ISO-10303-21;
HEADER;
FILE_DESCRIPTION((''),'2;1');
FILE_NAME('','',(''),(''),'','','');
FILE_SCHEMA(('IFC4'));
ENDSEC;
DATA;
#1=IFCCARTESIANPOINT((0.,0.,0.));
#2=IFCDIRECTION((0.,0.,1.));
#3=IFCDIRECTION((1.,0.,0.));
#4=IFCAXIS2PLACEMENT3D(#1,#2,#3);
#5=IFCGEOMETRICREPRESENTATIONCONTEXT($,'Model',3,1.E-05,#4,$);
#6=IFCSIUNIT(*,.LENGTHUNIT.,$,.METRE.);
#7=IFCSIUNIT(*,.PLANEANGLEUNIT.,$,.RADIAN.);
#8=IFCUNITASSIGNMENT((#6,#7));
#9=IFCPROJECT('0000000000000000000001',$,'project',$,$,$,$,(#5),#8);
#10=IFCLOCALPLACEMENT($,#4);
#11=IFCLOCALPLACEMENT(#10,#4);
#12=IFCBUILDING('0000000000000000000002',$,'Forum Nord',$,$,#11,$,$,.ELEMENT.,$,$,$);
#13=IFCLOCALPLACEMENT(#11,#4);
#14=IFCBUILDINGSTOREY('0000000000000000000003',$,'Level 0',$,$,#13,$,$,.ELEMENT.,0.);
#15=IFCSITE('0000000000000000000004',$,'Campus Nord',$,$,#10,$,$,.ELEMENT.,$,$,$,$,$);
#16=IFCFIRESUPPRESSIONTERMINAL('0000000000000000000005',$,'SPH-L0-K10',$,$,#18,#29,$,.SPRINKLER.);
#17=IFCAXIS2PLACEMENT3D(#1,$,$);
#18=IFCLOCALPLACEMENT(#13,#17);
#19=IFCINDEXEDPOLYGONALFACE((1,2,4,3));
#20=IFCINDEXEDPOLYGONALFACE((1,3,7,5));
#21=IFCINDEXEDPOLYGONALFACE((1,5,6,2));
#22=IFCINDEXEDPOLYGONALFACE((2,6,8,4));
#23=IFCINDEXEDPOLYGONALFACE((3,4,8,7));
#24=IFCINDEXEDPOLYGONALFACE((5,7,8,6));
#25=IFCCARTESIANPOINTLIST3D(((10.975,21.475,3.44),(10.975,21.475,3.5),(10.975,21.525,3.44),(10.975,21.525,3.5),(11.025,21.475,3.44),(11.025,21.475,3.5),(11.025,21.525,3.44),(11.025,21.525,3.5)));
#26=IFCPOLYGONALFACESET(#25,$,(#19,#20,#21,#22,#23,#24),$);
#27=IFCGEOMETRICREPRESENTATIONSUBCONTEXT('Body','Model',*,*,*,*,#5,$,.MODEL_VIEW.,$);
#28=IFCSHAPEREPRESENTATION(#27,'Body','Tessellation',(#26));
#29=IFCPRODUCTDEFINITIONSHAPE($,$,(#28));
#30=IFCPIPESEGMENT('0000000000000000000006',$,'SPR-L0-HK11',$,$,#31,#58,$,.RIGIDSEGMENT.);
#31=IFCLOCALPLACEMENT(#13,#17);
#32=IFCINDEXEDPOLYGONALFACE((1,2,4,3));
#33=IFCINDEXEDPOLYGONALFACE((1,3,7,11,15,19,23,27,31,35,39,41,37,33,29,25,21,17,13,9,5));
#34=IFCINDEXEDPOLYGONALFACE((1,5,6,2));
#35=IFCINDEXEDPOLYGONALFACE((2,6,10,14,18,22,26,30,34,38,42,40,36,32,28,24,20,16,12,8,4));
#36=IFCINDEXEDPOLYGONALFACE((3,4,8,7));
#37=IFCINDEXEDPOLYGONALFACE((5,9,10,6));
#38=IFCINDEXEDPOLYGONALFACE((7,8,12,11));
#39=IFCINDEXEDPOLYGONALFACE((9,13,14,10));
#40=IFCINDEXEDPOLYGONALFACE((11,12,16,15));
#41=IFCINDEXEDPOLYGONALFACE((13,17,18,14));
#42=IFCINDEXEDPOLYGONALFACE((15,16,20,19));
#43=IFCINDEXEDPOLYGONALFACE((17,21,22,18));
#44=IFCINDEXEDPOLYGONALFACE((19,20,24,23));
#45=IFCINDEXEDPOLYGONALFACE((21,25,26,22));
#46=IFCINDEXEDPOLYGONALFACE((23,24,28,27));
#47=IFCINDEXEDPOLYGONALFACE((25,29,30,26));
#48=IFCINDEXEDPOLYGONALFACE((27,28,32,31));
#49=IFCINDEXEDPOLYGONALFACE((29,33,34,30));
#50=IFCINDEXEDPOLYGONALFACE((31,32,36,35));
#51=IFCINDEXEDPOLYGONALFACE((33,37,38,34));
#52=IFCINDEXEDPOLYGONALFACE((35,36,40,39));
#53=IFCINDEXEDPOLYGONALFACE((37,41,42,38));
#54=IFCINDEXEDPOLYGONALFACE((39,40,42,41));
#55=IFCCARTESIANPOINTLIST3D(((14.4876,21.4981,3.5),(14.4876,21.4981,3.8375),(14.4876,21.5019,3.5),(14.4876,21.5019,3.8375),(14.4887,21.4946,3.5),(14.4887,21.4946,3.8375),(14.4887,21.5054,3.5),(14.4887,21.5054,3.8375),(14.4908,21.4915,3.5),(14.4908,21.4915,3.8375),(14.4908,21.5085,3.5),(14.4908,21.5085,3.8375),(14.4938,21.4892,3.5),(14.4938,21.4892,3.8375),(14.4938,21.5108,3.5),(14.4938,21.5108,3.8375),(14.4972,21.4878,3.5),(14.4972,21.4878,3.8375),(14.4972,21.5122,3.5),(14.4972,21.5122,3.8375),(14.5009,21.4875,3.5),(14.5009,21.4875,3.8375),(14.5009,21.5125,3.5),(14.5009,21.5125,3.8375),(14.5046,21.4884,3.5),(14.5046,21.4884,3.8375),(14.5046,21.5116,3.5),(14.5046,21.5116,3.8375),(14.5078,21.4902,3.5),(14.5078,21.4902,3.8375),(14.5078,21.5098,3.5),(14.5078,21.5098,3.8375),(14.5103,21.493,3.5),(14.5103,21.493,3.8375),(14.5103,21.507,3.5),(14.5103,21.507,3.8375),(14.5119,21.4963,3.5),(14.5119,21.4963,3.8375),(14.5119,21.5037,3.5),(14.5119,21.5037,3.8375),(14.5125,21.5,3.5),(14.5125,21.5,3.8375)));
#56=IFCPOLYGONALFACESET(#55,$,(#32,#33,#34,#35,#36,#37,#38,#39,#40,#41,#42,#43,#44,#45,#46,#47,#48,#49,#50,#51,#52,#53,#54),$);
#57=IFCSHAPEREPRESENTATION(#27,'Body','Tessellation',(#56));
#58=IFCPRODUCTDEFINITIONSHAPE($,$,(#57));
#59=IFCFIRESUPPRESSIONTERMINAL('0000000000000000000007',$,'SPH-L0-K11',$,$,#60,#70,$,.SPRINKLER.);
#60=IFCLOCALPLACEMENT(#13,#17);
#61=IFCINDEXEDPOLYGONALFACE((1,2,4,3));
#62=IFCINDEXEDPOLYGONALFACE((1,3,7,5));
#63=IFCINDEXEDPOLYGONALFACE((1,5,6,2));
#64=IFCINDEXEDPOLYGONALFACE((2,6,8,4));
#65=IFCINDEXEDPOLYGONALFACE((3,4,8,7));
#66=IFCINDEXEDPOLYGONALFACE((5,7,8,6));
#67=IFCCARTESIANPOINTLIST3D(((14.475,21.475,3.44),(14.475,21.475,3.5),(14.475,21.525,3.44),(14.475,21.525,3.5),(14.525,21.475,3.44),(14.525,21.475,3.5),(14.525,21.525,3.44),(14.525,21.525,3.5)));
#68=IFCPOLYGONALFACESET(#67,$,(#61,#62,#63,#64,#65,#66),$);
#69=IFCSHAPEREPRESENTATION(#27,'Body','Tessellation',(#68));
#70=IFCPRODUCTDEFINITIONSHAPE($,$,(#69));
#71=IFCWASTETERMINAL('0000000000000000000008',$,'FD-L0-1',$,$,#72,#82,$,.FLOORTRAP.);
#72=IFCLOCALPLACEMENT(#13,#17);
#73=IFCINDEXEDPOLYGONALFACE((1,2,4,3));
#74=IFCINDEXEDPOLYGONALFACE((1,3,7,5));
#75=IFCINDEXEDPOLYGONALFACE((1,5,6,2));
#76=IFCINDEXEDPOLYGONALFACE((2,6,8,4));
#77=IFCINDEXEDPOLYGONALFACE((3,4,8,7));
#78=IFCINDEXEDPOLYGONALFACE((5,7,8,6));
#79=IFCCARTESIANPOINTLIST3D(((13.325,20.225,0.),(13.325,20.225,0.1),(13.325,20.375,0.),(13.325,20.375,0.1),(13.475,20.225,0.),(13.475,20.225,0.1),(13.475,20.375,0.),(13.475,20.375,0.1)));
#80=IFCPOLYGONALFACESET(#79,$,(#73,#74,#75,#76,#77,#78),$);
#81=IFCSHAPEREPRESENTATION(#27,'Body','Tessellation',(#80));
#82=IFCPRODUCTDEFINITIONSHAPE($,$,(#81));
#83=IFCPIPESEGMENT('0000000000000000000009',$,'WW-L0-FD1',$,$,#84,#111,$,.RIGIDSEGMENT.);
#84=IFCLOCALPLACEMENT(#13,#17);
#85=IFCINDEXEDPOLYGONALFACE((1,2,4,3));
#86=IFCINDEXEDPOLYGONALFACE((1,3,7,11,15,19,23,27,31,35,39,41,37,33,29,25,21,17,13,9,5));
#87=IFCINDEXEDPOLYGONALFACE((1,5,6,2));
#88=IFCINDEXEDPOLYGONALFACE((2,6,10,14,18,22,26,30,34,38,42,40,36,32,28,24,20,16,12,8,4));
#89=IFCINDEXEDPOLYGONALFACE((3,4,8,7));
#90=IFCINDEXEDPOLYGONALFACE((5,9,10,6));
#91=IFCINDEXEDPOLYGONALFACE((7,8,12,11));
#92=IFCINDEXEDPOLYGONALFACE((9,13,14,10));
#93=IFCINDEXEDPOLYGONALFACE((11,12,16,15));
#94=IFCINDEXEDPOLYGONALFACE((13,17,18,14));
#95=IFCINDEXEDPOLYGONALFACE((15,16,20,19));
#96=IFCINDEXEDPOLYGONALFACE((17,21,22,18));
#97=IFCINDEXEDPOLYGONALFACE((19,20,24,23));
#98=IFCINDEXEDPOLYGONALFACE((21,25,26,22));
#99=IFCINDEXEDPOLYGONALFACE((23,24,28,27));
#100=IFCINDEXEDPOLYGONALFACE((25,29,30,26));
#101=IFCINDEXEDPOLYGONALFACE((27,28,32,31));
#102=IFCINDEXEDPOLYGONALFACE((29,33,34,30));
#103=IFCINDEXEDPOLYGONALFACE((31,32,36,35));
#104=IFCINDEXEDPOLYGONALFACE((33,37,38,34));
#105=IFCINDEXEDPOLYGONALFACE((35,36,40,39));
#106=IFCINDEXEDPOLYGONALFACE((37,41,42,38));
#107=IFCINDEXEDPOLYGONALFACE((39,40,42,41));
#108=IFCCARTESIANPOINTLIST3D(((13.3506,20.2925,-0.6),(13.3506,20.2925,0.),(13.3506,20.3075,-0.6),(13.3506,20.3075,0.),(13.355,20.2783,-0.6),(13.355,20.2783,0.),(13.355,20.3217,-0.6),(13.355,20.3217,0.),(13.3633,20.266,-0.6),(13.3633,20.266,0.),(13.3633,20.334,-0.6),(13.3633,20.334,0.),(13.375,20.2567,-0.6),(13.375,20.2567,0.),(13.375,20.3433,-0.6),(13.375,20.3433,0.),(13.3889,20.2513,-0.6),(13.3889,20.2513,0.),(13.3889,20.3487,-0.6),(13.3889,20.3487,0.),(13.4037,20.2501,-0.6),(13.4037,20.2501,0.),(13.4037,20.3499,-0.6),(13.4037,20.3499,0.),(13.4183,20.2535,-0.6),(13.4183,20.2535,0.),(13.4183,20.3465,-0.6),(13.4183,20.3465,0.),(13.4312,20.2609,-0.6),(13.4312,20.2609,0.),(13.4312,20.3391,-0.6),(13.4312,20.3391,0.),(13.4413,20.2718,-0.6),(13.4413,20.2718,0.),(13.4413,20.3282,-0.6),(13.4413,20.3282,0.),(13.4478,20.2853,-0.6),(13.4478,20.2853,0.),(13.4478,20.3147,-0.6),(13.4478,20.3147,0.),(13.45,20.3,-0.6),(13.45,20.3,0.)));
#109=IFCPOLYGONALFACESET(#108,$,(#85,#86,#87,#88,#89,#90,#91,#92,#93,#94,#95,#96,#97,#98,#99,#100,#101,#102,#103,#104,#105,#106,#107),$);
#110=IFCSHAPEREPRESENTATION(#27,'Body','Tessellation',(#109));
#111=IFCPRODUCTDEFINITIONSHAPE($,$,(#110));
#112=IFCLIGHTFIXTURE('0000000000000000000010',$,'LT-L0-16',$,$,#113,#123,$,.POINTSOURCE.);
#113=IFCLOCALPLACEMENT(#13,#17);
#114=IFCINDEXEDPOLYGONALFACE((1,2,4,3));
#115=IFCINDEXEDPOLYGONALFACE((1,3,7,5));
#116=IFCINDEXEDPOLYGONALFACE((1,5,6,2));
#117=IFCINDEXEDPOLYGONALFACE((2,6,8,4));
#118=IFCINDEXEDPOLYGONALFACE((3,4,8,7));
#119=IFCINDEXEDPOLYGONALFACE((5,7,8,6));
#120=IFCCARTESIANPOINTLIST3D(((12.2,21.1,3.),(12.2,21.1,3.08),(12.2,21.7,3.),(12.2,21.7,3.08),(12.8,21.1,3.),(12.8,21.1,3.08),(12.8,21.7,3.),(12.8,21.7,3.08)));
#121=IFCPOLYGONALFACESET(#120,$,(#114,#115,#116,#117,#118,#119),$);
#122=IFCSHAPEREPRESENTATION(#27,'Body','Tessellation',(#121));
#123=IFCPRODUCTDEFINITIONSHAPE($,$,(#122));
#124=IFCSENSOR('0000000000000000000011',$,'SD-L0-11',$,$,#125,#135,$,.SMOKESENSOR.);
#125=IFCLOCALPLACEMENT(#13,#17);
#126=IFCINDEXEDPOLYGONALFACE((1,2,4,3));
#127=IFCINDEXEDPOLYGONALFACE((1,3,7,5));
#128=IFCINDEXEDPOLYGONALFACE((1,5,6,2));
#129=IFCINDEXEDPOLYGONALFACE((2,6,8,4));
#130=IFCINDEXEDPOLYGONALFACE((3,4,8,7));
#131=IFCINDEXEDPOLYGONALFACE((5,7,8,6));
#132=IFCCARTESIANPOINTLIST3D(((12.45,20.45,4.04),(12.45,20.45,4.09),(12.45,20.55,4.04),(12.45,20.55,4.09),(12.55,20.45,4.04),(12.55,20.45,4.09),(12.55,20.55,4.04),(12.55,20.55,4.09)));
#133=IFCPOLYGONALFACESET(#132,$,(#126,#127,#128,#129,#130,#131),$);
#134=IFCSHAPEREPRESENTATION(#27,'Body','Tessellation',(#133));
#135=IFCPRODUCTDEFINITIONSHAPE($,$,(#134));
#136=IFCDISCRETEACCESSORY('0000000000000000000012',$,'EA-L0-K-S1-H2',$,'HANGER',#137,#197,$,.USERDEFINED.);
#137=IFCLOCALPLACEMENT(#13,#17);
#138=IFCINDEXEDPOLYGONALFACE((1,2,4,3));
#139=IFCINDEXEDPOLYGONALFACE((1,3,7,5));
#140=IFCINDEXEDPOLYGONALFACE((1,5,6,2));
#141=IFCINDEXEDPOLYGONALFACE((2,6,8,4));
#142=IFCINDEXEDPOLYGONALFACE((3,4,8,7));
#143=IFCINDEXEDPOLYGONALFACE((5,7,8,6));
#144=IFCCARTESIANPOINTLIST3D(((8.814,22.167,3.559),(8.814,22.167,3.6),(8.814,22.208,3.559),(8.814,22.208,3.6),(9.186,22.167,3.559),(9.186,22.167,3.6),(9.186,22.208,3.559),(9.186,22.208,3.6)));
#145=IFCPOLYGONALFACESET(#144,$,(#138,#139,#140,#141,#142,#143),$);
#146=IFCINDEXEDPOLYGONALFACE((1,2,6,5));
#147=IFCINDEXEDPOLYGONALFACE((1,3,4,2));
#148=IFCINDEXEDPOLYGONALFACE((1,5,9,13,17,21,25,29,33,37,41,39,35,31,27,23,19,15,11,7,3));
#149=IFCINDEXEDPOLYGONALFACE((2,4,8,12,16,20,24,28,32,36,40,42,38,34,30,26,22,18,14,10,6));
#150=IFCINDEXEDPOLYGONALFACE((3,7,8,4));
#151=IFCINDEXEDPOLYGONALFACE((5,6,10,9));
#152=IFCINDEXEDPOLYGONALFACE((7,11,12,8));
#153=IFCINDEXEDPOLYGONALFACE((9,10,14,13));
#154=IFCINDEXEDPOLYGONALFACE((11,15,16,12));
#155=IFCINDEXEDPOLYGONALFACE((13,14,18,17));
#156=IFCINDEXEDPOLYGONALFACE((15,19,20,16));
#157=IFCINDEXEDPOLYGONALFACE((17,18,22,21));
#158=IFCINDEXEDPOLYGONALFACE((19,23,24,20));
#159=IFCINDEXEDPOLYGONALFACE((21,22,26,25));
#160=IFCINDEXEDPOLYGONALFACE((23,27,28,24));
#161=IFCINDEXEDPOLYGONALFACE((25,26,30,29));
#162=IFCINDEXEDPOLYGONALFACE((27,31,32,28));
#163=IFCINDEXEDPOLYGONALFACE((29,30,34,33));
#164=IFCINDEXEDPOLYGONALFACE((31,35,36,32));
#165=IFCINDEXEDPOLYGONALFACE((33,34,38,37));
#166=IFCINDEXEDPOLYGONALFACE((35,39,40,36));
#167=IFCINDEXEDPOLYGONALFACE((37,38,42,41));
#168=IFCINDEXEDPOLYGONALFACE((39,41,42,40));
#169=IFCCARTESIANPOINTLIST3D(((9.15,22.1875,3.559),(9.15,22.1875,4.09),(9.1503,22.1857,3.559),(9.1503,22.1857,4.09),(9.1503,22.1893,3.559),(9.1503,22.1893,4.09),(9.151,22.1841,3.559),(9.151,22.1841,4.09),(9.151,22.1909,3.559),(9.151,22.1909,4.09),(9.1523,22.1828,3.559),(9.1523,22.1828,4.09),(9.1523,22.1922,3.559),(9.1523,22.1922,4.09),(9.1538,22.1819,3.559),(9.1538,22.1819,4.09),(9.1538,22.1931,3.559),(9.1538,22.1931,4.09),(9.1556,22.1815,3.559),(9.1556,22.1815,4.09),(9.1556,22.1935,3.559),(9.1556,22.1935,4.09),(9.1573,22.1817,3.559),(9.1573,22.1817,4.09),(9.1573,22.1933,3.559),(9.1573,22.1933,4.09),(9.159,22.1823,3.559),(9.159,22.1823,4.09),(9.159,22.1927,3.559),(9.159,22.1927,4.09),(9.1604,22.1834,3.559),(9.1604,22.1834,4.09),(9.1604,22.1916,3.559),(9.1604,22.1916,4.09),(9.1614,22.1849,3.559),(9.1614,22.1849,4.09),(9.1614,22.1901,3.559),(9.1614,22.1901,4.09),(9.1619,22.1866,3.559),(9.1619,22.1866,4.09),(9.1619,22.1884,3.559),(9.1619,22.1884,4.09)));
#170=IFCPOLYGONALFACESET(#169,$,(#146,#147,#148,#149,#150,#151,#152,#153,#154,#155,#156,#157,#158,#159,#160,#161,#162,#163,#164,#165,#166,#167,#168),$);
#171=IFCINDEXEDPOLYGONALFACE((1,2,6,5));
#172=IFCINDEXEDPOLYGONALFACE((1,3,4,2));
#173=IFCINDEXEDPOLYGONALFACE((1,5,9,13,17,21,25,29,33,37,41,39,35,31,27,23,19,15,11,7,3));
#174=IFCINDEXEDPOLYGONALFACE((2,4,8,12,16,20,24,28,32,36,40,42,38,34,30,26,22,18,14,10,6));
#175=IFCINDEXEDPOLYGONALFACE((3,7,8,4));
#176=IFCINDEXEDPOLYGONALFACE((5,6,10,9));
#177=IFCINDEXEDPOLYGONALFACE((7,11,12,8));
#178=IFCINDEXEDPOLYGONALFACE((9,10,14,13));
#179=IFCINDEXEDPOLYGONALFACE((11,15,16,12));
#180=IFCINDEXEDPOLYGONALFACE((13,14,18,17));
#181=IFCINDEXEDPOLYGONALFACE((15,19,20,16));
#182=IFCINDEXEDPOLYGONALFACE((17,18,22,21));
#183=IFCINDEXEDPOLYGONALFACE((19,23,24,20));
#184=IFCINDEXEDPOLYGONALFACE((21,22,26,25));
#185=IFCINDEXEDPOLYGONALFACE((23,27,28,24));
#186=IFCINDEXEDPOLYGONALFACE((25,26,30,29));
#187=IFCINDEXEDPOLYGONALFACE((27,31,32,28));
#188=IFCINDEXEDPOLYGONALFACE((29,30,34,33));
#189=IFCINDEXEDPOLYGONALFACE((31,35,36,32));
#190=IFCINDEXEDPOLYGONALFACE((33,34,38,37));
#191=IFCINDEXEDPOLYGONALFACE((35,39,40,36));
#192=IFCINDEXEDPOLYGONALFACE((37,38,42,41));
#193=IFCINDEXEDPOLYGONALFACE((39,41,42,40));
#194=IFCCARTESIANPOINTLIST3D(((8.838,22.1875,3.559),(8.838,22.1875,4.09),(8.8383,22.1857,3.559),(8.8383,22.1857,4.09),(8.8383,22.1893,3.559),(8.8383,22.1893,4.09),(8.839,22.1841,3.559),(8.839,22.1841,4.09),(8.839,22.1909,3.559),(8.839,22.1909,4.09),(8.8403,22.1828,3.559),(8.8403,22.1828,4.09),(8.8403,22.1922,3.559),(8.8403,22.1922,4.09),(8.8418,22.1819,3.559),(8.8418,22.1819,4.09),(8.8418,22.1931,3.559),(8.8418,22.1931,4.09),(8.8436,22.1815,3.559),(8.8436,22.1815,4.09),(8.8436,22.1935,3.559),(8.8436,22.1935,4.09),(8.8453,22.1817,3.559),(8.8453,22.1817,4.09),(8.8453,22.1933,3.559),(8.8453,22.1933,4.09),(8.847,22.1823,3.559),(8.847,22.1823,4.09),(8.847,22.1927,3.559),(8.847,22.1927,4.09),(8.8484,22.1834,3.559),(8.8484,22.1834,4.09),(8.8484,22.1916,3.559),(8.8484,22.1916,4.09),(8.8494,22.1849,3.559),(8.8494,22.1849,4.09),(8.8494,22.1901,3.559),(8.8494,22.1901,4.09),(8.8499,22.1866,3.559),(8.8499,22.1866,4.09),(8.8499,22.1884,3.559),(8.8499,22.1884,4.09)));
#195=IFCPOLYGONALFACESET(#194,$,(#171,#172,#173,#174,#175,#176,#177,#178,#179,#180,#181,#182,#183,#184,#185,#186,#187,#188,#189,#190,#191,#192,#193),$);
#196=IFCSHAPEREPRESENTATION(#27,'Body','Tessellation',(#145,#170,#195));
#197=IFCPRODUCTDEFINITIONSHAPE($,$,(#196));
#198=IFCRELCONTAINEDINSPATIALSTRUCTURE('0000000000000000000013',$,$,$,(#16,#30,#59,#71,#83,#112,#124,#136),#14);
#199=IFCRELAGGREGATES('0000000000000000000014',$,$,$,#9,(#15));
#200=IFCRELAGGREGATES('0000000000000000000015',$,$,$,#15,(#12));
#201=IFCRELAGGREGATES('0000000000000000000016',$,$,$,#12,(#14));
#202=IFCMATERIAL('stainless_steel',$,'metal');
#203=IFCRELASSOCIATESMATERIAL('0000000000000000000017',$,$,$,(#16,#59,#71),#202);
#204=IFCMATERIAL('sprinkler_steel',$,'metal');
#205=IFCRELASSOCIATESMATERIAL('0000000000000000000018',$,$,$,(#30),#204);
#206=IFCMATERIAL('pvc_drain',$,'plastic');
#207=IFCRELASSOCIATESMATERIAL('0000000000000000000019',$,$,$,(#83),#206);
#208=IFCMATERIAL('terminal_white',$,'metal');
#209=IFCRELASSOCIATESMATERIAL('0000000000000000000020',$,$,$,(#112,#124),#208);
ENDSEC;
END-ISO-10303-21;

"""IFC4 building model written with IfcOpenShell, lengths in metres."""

from ifc_helpers import new_model, si_unit, frame, frame_2d, origin_with_axes, origin_2d_with_axis, place, context, subcontext, project, spatial, rectangle, circle, extrude, material, element, save


model = new_model("IFC4")

# Units and contexts
model_context = context("Model", 3, precision=1e-05, world=origin_with_axes())
body_context = subcontext(model_context, "Body", "Model", "MODEL_VIEW")
ifc_project = project(units=[si_unit("LENGTHUNIT", "METRE"), si_unit("PLANEANGLEUNIT", "RADIAN")], contexts=[model_context])

# Site, building, storey
site_placement = place(None, origin_with_axes())
site = spatial("IfcSite", under=ifc_project, at=site_placement, Name="Campus Nord", CompositionType="ELEMENT")
building_placement = place(site_placement, origin_with_axes())
building = spatial("IfcBuilding", under=site, at=building_placement, Name="Forum Nord", CompositionType="ELEMENT")
storey_placement = place(building_placement, origin_with_axes())
storey = spatial("IfcBuildingStorey", under=building, at=storey_placement, Name="Level 0", CompositionType="ELEMENT", Elevation=0.0)

# Shared definitions
ifc_material_1 = material(Name="sprinkler_steel", Category="metal")

# Fire suppression terminal
ifc_material_2 = material(Name="stainless_steel", Category="metal")
fire_suppression_terminal_1_placement = place(storey_placement, frame((11.0, 21.5, 3.44), z_axis=(0.0, 0.0, 1.0), x_axis=(1.0, 0.0, 0.0)))
element("IfcFireSuppressionTerminal", 1, at=fire_suppression_terminal_1_placement, inside=storey, material=ifc_material_2, Name="SPH-L0-K10", PredefinedType="SPRINKLER", context=body_context, shape_type="SweptSolid", body=[
    extrude(rectangle(XDim=0.05, YDim=0.05, at=origin_2d_with_axis()), origin_with_axes(), (0.0, 0.0, 1.0), 0.06),
])

# Pipe segment
pipe_segment_1_placement = place(storey_placement, frame((14.5, 21.5, 3.8375), z_axis=(0.0, 0.0, -1.0), x_axis=(1.0, 0.0, 0.0)))
element("IfcPipeSegment", 2, at=pipe_segment_1_placement, inside=storey, material=ifc_material_1, Name="SPR-L0-HK11", PredefinedType="RIGIDSEGMENT", context=body_context, shape_type="SweptSolid", body=[
    extrude(circle(Radius=0.0125, at=origin_2d_with_axis()), origin_with_axes(), (0.0, 0.0, 1.0), 0.3375),
])

# Fire suppression terminal
fire_suppression_terminal_2_placement = place(storey_placement, frame((14.5, 21.5, 3.44), z_axis=(0.0, 0.0, 1.0), x_axis=(1.0, 0.0, 0.0)))
element("IfcFireSuppressionTerminal", 3, at=fire_suppression_terminal_2_placement, inside=storey, material=ifc_material_2, Name="SPH-L0-K11", PredefinedType="SPRINKLER", context=body_context, shape_type="SweptSolid", body=[
    extrude(rectangle(XDim=0.05, YDim=0.05, at=origin_2d_with_axis()), origin_with_axes(), (0.0, 0.0, 1.0), 0.06),
])

# Waste terminal
waste_terminal_placement = place(storey_placement, frame((13.4, 20.3, 0.0), z_axis=(0.0, 0.0, 1.0), x_axis=(1.0, 0.0, 0.0)))
element("IfcWasteTerminal", 4, at=waste_terminal_placement, inside=storey, material=ifc_material_2, Name="FD-L0-1", PredefinedType="FLOORTRAP", context=body_context, shape_type="SweptSolid", body=[
    extrude(rectangle(XDim=0.15, YDim=0.15, at=origin_2d_with_axis()), origin_with_axes(), (0.0, 0.0, 1.0), 0.1),
])

# Pipe segment
ifc_material_3 = material(Name="pvc_drain", Category="plastic")
pipe_segment_2_placement = place(storey_placement, frame((13.4, 20.3, 0.0), z_axis=(0.0, 0.0, -1.0), x_axis=(1.0, 0.0, 0.0)))
element("IfcPipeSegment", 5, at=pipe_segment_2_placement, inside=storey, material=ifc_material_3, Name="WW-L0-FD1", PredefinedType="RIGIDSEGMENT", context=body_context, shape_type="SweptSolid", body=[
    extrude(circle(Radius=0.05, at=origin_2d_with_axis()), origin_with_axes(), (0.0, 0.0, 1.0), 0.6),
])

# Light fixture
ifc_material_4 = material(Name="terminal_white", Category="metal")
light_fixture_placement = place(storey_placement, frame((12.5, 21.4, 3.0), z_axis=(0.0, 0.0, 1.0), x_axis=(1.0, 0.0, 0.0)))
element("IfcLightFixture", 6, at=light_fixture_placement, inside=storey, material=ifc_material_4, Name="LT-L0-16", PredefinedType="POINTSOURCE", context=body_context, shape_type="SweptSolid", body=[
    extrude(rectangle(XDim=0.6, YDim=0.6, at=origin_2d_with_axis()), origin_with_axes(), (0.0, 0.0, 1.0), 0.08),
])

# Sensor
sensor_placement = place(storey_placement, frame((12.5, 20.5, 4.04), z_axis=(0.0, 0.0, 1.0), x_axis=(1.0, 0.0, 0.0)))
element("IfcSensor", 7, at=sensor_placement, inside=storey, material=ifc_material_4, Name="SD-L0-11", PredefinedType="SMOKESENSOR", context=body_context, shape_type="SweptSolid", body=[
    extrude(rectangle(XDim=0.1, YDim=0.1, at=origin_2d_with_axis()), origin_with_axes(), (0.0, 0.0, 1.0), 0.05),
])

# Discrete accessory
for number, where, z_axis, x_axis, name in (
    (8, (9.0, 22.1875, 3.6), (0.0, 0.0, 1.0), (-1.0, 0.0, 0.0), "EA-L0-K-S1-H2"),
):
    element("IfcDiscreteAccessory", number, at=place(storey_placement, frame(where, z_axis=z_axis, x_axis=x_axis)), inside=storey, Name=name, ObjectType="HANGER", PredefinedType="USERDEFINED", context=body_context, shape_type="SweptSolid", body=[
        extrude(rectangle(XDim=0.372, YDim=0.041, at=origin_2d_with_axis()), frame((0.0, 0.0, -0.041), z_axis=(0.0, 0.0, 1.0), x_axis=(1.0, 0.0, 0.0)), (0.0, 0.0, 1.0), 0.041),
        extrude(circle(Radius=0.006, at=frame_2d((-0.156, 0.0), x_axis=(1.0, 0.0))), frame((0.0, 0.0, -0.041), z_axis=(0.0, 0.0, 1.0), x_axis=(1.0, 0.0, 0.0)), (0.0, 0.0, 1.0), 0.531),
        extrude(circle(Radius=0.006, at=frame_2d((0.156, 0.0), x_axis=(1.0, 0.0))), frame((0.0, 0.0, -0.041), z_axis=(0.0, 0.0, 1.0), x_axis=(1.0, 0.0, 0.0)), (0.0, 0.0, 1.0), 0.531),
    ])

save(model, "model.ifc")
